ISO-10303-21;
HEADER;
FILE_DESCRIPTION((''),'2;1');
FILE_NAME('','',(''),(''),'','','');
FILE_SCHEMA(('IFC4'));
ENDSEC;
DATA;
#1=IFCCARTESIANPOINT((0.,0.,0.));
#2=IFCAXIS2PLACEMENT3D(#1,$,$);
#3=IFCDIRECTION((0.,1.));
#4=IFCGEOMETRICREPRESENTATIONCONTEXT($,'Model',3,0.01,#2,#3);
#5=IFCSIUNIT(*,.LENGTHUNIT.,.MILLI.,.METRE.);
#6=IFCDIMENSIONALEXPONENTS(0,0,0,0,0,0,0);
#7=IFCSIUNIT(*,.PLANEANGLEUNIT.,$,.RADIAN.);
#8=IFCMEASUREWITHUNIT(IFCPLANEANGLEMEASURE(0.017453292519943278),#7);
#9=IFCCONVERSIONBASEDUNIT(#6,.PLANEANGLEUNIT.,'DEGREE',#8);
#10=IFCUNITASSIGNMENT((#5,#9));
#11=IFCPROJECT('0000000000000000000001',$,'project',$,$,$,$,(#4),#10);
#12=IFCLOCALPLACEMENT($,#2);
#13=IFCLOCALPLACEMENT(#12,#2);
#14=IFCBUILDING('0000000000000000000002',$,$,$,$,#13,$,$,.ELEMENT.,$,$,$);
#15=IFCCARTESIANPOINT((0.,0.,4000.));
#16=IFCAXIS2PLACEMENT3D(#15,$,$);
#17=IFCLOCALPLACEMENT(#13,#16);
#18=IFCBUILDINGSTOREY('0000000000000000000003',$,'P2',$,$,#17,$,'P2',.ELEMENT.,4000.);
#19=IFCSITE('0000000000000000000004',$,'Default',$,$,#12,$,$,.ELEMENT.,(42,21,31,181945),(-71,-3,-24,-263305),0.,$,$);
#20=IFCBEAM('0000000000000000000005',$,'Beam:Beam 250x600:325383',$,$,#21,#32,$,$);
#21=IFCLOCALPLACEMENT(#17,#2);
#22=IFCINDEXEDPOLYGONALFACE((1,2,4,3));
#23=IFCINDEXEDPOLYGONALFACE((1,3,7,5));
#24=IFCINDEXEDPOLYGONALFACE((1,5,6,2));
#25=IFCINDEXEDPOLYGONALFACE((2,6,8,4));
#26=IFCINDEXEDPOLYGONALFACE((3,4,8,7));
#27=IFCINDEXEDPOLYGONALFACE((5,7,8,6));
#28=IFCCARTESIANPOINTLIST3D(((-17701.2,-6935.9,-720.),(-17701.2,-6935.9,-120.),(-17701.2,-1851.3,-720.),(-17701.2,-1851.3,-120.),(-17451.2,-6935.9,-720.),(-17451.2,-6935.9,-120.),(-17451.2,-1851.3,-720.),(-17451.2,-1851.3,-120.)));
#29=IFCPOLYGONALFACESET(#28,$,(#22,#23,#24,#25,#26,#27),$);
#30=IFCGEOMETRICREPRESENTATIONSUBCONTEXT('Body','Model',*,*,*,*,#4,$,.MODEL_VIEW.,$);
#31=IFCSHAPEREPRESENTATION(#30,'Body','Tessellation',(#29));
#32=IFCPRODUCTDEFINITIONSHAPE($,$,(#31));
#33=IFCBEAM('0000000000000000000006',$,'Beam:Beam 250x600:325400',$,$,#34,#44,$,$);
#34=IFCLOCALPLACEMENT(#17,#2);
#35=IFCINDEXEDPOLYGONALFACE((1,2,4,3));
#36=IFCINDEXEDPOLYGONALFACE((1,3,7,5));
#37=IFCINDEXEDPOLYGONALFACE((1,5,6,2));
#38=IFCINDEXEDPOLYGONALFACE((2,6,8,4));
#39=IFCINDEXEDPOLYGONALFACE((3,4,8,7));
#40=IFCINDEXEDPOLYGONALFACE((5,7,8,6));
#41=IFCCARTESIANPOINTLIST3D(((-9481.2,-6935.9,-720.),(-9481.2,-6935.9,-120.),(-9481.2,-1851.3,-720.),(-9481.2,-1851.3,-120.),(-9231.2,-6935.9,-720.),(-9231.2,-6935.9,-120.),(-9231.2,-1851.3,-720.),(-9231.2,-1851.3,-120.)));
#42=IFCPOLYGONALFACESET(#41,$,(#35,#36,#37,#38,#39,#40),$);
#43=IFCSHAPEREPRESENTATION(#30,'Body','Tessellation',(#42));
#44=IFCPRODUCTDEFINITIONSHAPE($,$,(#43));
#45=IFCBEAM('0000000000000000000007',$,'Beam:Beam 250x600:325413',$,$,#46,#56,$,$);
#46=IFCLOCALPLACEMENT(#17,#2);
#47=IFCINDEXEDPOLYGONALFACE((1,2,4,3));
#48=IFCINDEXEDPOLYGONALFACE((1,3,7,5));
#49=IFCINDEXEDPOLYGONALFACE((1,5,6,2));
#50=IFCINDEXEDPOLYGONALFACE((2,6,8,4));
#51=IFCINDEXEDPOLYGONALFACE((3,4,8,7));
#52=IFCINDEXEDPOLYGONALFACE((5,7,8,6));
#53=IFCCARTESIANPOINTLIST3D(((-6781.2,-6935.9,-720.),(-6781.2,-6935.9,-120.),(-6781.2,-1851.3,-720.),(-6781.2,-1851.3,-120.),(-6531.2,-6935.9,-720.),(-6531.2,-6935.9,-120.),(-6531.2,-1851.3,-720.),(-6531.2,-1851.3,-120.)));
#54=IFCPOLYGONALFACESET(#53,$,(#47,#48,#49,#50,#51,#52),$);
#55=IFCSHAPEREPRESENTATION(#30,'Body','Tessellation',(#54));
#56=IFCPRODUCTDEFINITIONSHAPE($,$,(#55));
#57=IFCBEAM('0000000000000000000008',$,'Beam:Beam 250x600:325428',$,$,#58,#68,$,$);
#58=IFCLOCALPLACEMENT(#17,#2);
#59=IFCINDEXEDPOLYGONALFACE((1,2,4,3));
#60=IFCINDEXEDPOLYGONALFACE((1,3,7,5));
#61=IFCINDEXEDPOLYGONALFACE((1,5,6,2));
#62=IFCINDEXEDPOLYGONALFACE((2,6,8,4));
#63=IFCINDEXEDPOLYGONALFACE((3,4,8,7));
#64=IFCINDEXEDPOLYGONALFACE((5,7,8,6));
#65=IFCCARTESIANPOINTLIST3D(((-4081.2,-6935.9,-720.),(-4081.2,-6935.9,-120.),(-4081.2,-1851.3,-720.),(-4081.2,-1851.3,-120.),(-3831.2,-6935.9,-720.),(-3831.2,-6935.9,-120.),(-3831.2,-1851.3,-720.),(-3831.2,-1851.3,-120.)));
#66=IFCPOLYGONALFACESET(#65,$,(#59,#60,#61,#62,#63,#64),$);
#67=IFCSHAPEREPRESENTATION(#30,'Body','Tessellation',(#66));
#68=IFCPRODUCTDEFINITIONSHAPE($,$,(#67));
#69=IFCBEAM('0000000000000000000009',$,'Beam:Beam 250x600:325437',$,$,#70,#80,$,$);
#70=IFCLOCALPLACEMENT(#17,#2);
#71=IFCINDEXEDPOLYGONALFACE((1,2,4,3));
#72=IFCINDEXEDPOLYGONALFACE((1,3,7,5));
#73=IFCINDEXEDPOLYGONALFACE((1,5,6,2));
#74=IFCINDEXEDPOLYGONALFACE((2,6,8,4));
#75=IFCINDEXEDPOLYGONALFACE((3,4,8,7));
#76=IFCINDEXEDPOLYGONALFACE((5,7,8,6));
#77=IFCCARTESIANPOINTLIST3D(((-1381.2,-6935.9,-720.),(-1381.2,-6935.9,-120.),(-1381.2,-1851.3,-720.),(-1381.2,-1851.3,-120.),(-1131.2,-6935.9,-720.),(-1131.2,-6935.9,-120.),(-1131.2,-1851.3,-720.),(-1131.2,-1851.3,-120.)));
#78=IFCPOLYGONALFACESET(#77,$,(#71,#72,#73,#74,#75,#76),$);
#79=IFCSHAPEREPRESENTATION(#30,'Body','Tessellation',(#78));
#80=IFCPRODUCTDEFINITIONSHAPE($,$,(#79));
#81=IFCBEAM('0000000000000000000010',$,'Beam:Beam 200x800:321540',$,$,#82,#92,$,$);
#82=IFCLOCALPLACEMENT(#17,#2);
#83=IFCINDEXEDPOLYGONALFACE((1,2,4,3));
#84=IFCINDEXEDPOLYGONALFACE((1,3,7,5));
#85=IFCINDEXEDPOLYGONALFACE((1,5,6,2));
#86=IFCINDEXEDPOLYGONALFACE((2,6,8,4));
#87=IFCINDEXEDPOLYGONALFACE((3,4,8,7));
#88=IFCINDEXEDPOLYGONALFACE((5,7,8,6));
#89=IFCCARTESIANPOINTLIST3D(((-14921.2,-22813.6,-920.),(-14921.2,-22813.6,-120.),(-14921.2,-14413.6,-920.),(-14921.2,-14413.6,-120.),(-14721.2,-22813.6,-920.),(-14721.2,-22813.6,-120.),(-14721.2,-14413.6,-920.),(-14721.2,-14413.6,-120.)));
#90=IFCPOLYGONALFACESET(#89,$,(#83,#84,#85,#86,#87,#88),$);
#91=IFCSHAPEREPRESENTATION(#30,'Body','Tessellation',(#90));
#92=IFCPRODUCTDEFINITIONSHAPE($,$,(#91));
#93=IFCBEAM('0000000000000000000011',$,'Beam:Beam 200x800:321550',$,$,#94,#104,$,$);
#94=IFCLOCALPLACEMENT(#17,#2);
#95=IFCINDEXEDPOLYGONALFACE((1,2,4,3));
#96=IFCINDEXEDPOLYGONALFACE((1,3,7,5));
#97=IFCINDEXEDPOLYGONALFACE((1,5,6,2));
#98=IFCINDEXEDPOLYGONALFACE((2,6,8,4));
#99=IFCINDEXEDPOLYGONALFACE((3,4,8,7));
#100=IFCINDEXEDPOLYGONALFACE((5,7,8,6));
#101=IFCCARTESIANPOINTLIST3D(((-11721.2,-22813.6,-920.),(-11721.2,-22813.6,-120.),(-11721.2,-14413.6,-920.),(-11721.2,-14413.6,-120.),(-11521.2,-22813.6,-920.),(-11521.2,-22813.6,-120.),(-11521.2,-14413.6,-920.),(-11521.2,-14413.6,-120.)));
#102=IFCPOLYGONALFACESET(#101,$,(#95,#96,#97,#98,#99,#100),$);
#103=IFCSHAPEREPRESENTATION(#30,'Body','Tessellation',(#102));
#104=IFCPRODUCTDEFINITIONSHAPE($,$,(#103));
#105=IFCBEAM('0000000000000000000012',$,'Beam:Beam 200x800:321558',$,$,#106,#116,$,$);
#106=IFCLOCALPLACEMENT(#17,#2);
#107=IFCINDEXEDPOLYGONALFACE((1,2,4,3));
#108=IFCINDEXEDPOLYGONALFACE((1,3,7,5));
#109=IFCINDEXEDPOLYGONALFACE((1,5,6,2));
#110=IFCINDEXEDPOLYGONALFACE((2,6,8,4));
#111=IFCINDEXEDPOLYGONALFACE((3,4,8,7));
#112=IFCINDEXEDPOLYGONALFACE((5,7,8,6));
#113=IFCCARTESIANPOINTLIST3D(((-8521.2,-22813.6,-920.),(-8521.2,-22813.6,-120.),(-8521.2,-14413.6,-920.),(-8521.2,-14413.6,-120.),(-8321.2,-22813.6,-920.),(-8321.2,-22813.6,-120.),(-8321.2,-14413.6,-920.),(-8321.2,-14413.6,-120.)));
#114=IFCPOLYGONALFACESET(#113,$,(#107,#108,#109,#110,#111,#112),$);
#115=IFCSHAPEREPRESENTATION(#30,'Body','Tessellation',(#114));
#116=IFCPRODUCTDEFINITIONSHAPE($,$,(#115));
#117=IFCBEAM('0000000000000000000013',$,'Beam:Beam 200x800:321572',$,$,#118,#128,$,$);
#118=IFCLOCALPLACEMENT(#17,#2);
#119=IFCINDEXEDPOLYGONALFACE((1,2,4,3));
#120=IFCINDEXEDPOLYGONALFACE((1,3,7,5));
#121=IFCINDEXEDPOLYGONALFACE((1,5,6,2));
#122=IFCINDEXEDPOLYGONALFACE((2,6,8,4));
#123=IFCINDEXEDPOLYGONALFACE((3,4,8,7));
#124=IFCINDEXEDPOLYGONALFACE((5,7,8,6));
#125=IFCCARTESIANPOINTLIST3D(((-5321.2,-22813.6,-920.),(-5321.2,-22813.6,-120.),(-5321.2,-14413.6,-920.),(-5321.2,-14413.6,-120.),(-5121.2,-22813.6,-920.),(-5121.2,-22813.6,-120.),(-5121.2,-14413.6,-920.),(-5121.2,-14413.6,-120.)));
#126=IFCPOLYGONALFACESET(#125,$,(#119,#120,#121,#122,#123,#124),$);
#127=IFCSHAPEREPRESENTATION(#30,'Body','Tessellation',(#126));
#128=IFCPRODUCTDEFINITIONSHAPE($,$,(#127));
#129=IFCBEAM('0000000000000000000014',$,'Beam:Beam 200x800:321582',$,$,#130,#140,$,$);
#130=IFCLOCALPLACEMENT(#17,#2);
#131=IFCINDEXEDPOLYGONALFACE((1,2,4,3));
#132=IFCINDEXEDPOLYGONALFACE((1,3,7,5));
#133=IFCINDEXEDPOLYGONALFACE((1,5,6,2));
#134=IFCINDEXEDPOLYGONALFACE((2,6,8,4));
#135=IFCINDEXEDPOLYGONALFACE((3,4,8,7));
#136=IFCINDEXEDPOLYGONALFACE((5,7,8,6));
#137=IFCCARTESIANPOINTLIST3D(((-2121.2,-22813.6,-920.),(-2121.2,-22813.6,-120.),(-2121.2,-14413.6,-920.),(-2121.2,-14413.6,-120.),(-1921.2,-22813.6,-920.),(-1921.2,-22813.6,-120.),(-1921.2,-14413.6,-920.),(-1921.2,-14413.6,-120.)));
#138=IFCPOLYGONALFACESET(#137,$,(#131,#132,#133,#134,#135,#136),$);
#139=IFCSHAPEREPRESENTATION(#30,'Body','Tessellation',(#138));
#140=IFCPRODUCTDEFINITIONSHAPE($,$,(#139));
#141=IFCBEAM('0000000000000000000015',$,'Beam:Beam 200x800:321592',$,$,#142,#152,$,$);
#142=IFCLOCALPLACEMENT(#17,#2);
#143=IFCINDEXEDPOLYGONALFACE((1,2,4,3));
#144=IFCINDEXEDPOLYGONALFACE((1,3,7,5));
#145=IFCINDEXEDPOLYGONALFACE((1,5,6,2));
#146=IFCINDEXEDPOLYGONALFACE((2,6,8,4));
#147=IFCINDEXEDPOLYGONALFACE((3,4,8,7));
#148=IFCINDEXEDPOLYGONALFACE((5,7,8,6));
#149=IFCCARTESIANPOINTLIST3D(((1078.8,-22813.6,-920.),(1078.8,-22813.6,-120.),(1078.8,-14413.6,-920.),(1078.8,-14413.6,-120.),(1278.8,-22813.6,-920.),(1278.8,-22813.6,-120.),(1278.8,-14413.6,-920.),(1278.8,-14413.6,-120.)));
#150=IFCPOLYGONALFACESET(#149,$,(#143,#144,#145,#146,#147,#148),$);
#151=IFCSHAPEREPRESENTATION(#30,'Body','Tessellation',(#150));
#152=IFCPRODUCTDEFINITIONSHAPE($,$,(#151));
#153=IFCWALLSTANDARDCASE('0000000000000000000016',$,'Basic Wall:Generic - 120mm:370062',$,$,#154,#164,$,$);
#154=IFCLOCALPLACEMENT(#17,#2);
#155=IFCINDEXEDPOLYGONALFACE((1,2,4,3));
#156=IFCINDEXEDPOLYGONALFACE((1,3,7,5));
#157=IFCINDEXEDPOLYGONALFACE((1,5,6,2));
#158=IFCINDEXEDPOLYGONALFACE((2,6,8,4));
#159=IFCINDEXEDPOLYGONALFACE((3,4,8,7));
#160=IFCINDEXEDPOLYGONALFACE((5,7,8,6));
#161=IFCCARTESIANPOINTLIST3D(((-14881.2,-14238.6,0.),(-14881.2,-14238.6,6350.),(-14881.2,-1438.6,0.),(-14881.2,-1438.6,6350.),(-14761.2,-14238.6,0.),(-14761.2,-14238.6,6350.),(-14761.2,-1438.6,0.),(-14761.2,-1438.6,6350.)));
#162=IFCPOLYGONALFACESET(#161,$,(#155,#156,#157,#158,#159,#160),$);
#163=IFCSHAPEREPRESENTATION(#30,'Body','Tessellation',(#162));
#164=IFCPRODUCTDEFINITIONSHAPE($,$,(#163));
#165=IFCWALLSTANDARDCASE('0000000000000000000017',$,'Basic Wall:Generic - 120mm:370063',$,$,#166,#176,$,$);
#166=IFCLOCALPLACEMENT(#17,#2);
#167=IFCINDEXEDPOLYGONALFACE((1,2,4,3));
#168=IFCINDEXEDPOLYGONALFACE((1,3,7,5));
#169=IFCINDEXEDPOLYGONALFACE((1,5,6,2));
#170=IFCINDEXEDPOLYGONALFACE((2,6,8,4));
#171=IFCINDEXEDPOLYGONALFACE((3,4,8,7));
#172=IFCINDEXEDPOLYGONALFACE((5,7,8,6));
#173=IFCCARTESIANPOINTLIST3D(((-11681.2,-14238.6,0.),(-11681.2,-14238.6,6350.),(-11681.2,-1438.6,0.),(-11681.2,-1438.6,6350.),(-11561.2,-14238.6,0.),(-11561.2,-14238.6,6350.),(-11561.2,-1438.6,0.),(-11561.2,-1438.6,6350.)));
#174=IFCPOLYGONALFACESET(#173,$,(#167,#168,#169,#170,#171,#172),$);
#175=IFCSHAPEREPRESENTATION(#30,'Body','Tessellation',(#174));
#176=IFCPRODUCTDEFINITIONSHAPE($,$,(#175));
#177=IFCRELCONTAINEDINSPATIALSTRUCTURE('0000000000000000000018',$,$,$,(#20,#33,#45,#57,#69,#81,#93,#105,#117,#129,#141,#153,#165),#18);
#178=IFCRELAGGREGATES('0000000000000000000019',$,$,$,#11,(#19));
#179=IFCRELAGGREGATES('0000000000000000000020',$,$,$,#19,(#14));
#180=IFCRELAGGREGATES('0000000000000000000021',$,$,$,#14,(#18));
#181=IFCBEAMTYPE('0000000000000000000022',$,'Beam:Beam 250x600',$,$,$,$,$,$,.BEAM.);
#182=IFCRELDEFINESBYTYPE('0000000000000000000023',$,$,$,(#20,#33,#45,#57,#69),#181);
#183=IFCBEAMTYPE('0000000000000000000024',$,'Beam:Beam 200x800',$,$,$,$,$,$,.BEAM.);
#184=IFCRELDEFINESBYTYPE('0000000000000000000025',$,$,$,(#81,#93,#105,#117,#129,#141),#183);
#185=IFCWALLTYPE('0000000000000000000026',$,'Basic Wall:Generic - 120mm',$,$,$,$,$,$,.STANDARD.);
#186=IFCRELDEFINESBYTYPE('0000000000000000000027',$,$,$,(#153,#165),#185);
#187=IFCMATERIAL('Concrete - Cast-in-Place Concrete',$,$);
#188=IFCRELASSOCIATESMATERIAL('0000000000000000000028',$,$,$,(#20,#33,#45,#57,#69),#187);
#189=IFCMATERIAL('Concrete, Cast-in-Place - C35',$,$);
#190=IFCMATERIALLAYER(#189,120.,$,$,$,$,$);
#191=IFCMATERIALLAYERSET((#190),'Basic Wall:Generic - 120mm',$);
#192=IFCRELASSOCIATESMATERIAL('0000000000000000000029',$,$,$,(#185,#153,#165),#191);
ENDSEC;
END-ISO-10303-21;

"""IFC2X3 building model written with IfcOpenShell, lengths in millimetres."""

from ifc_helpers import new_model, entity, si_unit, converted_unit, direction, frame, frame_2d, origin, origin_2d_with_axis, place, context, subcontext, project, spatial, rectangle, extrude, material, layer, layer_set, layer_usage, type_object, element, save


model = new_model("IFC2X3")

# Units and contexts
model_context = context("Model", 3, precision=0.01, world=origin(), true_north=direction((0.0, 1.0)))
body_context = subcontext(model_context, "Body", "Model", "MODEL_VIEW")
ifc_project = project(units=[si_unit("LENGTHUNIT", "METRE", prefix="MILLI"), converted_unit("PLANEANGLEUNIT", "DEGREE", entity("IfcPlaneAngleMeasure", 0.017453292519943278), si_unit("PLANEANGLEUNIT", "RADIAN"), dimensions=[0, 0, 0, 0, 0, 0, 0])], contexts=[model_context])

# Site, building, storey
site_placement = place(None, origin())
site = spatial("IfcSite", under=ifc_project, at=site_placement, Name="Default", CompositionType="ELEMENT", RefLatitude=(42, 21, 31, 181945), RefLongitude=(-71, -3, -24, -263305), RefElevation=0.0)
building_placement = place(site_placement, origin())
building = spatial("IfcBuilding", under=site, at=building_placement, CompositionType="ELEMENT")
storey_placement = place(building_placement, frame((0.0, 0.0, 4000.0)))
storey = spatial("IfcBuildingStorey", under=building, at=storey_placement, Name="P2", LongName="P2", CompositionType="ELEMENT", Elevation=4000.0)

# Shared definitions
ifc_material_1 = material(Name="Concrete, Cast-in-Place - C35")

# Beams
ifc_material_2 = material(Name="Concrete - Cast-in-Place Concrete")
beam_type_1 = type_object("IfcBeamType", Name="Beam:Beam 250x600", PredefinedType="BEAM")
beam_1_placement = place(storey_placement, frame((-17576.2, -6978.6, -120.0), z_axis=(0.0, 0.0, 1.0), x_axis=(0.0, 1.0, 0.0)))
element("IfcBeam", 1, at=beam_1_placement, inside=storey, type_object=beam_type_1, material=ifc_material_2, Name="Beam:Beam 250x600:325383", context=body_context, shape_type="SweptSolid", body=[
    extrude(rectangle(XDim=600.0, YDim=250.0, at=frame_2d((0.0, 0.0), x_axis=(1.0, 0.0))), frame((42.7, 0.0, -300.0), z_axis=(1.0, 0.0, 0.0), x_axis=(0.0, 0.0, -1.0)), (0.0, 0.0, 1.0), 5084.6),
])
for number, where, z_axis, x_axis, name in (
    (2, (-9356.2, -6978.6, -120.0), (0.0, 0.0, 1.0), (0.0, 1.0, 0.0), "Beam:Beam 250x600:325400"),
    (3, (-6656.2, -6978.6, -120.0), (0.0, 0.0, 1.0), (0.0, 1.0, 0.0), "Beam:Beam 250x600:325413"),
    (4, (-3956.2, -6978.6, -120.0), (0.0, 0.0, 1.0), (0.0, 1.0, 0.0), "Beam:Beam 250x600:325428"),
):
    element("IfcBeam", number, at=place(storey_placement, frame(where, z_axis=z_axis, x_axis=x_axis)), inside=storey, type_object=beam_type_1, material=ifc_material_2, Name=name, context=body_context, shape_type="SweptSolid", body=[
        extrude(rectangle(XDim=600.0, YDim=250.0, at=frame_2d((0.0, 0.0), x_axis=(1.0, 0.0))), frame((42.7, 0.0, -300.0), z_axis=(1.0, 0.0, 0.0), x_axis=(0.0, 0.0, -1.0)), (0.0, 0.0, 1.0), 5084.6),
    ])
beam_2_placement = place(storey_placement, frame((-1256.2, -6978.6, -120.0), z_axis=(0.0, 0.0, 1.0), x_axis=(0.0, 1.0, 0.0)))
element("IfcBeam", 5, at=beam_2_placement, inside=storey, type_object=beam_type_1, material=ifc_material_2, Name="Beam:Beam 250x600:325437", context=body_context, shape_type="SweptSolid", body=[
    extrude(rectangle(XDim=600.0, YDim=250.0, at=frame_2d((0.0, 0.0), x_axis=(1.0, 0.0))), frame((42.7, 0.0, -300.0), z_axis=(1.0, 0.0, 0.0), x_axis=(0.0, 0.0, -1.0)), (0.0, 0.0, 1.0), 5084.6),
])
beam_type_2 = type_object("IfcBeamType", Name="Beam:Beam 200x800", PredefinedType="BEAM")
beam_3_placement = place(storey_placement, frame((-14846.2, -14413.6, -120.0), z_axis=(0.0, 0.0, 1.0), x_axis=(0.0, -1.0, 0.0)))
element("IfcBeam", 6, at=beam_3_placement, inside=storey, type_object=beam_type_2, Name="Beam:Beam 200x800:321540", context=body_context, shape_type="SweptSolid", body=[
    extrude(rectangle(XDim=800.0, YDim=200.0, at=frame_2d((0.0, 0.0), x_axis=(1.0, 0.0))), frame((0.0, 25.0, -400.0), z_axis=(1.0, 0.0, 0.0), x_axis=(0.0, 0.0, -1.0)), (0.0, 0.0, 1.0), 8400.0),
])
beam_4_placement = place(storey_placement, frame((-11646.2, -14413.6, -120.0), z_axis=(0.0, 0.0, 1.0), x_axis=(0.0, -1.0, 0.0)))
element("IfcBeam", 7, at=beam_4_placement, inside=storey, type_object=beam_type_2, Name="Beam:Beam 200x800:321550", context=body_context, shape_type="SweptSolid", body=[
    extrude(rectangle(XDim=800.0, YDim=200.0, at=frame_2d((0.0, 0.0), x_axis=(1.0, 0.0))), frame((0.0, 25.0, -400.0), z_axis=(1.0, 0.0, 0.0), x_axis=(0.0, 0.0, -1.0)), (0.0, 0.0, 1.0), 8400.0),
])
for number, where, z_axis, x_axis, name in (
    (8, (-8446.2, -14413.6, -120.0), (0.0, 0.0, 1.0), (0.0, -1.0, 0.0), "Beam:Beam 200x800:321558"),
    (9, (-5246.2, -14413.6, -120.0), (0.0, 0.0, 1.0), (0.0, -1.0, 0.0), "Beam:Beam 200x800:321572"),
):
    element("IfcBeam", number, at=place(storey_placement, frame(where, z_axis=z_axis, x_axis=x_axis)), inside=storey, type_object=beam_type_2, Name=name, context=body_context, shape_type="SweptSolid", body=[
        extrude(rectangle(XDim=800.0, YDim=200.0, at=origin_2d_with_axis()), frame((0.0, 25.0, -400.0), z_axis=(1.0, 0.0, 0.0), x_axis=(0.0, 0.0, -1.0)), (0.0, 0.0, 1.0), 8400.0),
    ])
beam_5_placement = place(storey_placement, frame((-2046.2, -14413.6, -120.0), z_axis=(0.0, 0.0, 1.0), x_axis=(0.0, -1.0, 0.0)))
element("IfcBeam", 10, at=beam_5_placement, inside=storey, type_object=beam_type_2, Name="Beam:Beam 200x800:321582", context=body_context, shape_type="SweptSolid", body=[
    extrude(rectangle(XDim=800.0, YDim=200.0, at=frame_2d((0.0, 0.0), x_axis=(1.0, 0.0))), frame((0.0, 25.0, -400.0), z_axis=(1.0, 0.0, 0.0), x_axis=(0.0, 0.0, -1.0)), (0.0, 0.0, 1.0), 8400.0),
])
beam_6_placement = place(storey_placement, frame((1153.8, -14413.6, -120.0), z_axis=(0.0, 0.0, 1.0), x_axis=(0.0, -1.0, 0.0)))
element("IfcBeam", 11, at=beam_6_placement, inside=storey, type_object=beam_type_2, Name="Beam:Beam 200x800:321592", context=body_context, shape_type="SweptSolid", body=[
    extrude(rectangle(XDim=800.0, YDim=200.0, at=frame_2d((0.0, 0.0), x_axis=(1.0, 0.0))), frame((0.0, 25.0, -400.0), z_axis=(1.0, 0.0, 0.0), x_axis=(0.0, 0.0, -1.0)), (0.0, 0.0, 1.0), 8400.0),
])

# Walls
ifc_layer = layer(ifc_material_1, 120.0)
ifc_layer_set = layer_set([ifc_layer], Name="Basic Wall:Generic - 120mm")
ifc_layer_usage_1 = layer_usage(ifc_layer_set, "AXIS2", "NEGATIVE", 60.0)
wall_type = type_object("IfcWallType", Name="Basic Wall:Generic - 120mm", PredefinedType="STANDARD", material=ifc_layer_set)
wall_1_placement = place(storey_placement, frame((-14821.2, -1438.6, 0.0), z_axis=(0.0, 0.0, 1.0), x_axis=(0.0, -1.0, 0.0)))
element("IfcWallStandardCase", 12, at=wall_1_placement, inside=storey, type_object=wall_type, material=ifc_layer_usage_1, Name="Basic Wall:Generic - 120mm:370062", context=body_context, shape_type="SweptSolid", body=[
    extrude(rectangle(XDim=12800.0, YDim=120.0, at=frame_2d((6400.0, 0.0), x_axis=(-1.0, 0.0))), origin(), (0.0, 0.0, 1.0), 6350.0),
])
ifc_layer_usage_2 = layer_usage(ifc_layer_set, "AXIS2", "NEGATIVE", 60.0)
wall_2_placement = place(storey_placement, frame((-11621.2, -1438.6, 0.0), z_axis=(0.0, 0.0, 1.0), x_axis=(0.0, -1.0, 0.0)))
element("IfcWallStandardCase", 13, at=wall_2_placement, inside=storey, type_object=wall_type, material=ifc_layer_usage_2, Name="Basic Wall:Generic - 120mm:370063", context=body_context, shape_type="SweptSolid", body=[
    extrude(rectangle(XDim=12800.0, YDim=120.0, at=frame_2d((6400.0, 0.0), x_axis=(-1.0, 0.0))), origin(), (0.0, 0.0, 1.0), 6350.0),
])

save(model, "model.ifc")
